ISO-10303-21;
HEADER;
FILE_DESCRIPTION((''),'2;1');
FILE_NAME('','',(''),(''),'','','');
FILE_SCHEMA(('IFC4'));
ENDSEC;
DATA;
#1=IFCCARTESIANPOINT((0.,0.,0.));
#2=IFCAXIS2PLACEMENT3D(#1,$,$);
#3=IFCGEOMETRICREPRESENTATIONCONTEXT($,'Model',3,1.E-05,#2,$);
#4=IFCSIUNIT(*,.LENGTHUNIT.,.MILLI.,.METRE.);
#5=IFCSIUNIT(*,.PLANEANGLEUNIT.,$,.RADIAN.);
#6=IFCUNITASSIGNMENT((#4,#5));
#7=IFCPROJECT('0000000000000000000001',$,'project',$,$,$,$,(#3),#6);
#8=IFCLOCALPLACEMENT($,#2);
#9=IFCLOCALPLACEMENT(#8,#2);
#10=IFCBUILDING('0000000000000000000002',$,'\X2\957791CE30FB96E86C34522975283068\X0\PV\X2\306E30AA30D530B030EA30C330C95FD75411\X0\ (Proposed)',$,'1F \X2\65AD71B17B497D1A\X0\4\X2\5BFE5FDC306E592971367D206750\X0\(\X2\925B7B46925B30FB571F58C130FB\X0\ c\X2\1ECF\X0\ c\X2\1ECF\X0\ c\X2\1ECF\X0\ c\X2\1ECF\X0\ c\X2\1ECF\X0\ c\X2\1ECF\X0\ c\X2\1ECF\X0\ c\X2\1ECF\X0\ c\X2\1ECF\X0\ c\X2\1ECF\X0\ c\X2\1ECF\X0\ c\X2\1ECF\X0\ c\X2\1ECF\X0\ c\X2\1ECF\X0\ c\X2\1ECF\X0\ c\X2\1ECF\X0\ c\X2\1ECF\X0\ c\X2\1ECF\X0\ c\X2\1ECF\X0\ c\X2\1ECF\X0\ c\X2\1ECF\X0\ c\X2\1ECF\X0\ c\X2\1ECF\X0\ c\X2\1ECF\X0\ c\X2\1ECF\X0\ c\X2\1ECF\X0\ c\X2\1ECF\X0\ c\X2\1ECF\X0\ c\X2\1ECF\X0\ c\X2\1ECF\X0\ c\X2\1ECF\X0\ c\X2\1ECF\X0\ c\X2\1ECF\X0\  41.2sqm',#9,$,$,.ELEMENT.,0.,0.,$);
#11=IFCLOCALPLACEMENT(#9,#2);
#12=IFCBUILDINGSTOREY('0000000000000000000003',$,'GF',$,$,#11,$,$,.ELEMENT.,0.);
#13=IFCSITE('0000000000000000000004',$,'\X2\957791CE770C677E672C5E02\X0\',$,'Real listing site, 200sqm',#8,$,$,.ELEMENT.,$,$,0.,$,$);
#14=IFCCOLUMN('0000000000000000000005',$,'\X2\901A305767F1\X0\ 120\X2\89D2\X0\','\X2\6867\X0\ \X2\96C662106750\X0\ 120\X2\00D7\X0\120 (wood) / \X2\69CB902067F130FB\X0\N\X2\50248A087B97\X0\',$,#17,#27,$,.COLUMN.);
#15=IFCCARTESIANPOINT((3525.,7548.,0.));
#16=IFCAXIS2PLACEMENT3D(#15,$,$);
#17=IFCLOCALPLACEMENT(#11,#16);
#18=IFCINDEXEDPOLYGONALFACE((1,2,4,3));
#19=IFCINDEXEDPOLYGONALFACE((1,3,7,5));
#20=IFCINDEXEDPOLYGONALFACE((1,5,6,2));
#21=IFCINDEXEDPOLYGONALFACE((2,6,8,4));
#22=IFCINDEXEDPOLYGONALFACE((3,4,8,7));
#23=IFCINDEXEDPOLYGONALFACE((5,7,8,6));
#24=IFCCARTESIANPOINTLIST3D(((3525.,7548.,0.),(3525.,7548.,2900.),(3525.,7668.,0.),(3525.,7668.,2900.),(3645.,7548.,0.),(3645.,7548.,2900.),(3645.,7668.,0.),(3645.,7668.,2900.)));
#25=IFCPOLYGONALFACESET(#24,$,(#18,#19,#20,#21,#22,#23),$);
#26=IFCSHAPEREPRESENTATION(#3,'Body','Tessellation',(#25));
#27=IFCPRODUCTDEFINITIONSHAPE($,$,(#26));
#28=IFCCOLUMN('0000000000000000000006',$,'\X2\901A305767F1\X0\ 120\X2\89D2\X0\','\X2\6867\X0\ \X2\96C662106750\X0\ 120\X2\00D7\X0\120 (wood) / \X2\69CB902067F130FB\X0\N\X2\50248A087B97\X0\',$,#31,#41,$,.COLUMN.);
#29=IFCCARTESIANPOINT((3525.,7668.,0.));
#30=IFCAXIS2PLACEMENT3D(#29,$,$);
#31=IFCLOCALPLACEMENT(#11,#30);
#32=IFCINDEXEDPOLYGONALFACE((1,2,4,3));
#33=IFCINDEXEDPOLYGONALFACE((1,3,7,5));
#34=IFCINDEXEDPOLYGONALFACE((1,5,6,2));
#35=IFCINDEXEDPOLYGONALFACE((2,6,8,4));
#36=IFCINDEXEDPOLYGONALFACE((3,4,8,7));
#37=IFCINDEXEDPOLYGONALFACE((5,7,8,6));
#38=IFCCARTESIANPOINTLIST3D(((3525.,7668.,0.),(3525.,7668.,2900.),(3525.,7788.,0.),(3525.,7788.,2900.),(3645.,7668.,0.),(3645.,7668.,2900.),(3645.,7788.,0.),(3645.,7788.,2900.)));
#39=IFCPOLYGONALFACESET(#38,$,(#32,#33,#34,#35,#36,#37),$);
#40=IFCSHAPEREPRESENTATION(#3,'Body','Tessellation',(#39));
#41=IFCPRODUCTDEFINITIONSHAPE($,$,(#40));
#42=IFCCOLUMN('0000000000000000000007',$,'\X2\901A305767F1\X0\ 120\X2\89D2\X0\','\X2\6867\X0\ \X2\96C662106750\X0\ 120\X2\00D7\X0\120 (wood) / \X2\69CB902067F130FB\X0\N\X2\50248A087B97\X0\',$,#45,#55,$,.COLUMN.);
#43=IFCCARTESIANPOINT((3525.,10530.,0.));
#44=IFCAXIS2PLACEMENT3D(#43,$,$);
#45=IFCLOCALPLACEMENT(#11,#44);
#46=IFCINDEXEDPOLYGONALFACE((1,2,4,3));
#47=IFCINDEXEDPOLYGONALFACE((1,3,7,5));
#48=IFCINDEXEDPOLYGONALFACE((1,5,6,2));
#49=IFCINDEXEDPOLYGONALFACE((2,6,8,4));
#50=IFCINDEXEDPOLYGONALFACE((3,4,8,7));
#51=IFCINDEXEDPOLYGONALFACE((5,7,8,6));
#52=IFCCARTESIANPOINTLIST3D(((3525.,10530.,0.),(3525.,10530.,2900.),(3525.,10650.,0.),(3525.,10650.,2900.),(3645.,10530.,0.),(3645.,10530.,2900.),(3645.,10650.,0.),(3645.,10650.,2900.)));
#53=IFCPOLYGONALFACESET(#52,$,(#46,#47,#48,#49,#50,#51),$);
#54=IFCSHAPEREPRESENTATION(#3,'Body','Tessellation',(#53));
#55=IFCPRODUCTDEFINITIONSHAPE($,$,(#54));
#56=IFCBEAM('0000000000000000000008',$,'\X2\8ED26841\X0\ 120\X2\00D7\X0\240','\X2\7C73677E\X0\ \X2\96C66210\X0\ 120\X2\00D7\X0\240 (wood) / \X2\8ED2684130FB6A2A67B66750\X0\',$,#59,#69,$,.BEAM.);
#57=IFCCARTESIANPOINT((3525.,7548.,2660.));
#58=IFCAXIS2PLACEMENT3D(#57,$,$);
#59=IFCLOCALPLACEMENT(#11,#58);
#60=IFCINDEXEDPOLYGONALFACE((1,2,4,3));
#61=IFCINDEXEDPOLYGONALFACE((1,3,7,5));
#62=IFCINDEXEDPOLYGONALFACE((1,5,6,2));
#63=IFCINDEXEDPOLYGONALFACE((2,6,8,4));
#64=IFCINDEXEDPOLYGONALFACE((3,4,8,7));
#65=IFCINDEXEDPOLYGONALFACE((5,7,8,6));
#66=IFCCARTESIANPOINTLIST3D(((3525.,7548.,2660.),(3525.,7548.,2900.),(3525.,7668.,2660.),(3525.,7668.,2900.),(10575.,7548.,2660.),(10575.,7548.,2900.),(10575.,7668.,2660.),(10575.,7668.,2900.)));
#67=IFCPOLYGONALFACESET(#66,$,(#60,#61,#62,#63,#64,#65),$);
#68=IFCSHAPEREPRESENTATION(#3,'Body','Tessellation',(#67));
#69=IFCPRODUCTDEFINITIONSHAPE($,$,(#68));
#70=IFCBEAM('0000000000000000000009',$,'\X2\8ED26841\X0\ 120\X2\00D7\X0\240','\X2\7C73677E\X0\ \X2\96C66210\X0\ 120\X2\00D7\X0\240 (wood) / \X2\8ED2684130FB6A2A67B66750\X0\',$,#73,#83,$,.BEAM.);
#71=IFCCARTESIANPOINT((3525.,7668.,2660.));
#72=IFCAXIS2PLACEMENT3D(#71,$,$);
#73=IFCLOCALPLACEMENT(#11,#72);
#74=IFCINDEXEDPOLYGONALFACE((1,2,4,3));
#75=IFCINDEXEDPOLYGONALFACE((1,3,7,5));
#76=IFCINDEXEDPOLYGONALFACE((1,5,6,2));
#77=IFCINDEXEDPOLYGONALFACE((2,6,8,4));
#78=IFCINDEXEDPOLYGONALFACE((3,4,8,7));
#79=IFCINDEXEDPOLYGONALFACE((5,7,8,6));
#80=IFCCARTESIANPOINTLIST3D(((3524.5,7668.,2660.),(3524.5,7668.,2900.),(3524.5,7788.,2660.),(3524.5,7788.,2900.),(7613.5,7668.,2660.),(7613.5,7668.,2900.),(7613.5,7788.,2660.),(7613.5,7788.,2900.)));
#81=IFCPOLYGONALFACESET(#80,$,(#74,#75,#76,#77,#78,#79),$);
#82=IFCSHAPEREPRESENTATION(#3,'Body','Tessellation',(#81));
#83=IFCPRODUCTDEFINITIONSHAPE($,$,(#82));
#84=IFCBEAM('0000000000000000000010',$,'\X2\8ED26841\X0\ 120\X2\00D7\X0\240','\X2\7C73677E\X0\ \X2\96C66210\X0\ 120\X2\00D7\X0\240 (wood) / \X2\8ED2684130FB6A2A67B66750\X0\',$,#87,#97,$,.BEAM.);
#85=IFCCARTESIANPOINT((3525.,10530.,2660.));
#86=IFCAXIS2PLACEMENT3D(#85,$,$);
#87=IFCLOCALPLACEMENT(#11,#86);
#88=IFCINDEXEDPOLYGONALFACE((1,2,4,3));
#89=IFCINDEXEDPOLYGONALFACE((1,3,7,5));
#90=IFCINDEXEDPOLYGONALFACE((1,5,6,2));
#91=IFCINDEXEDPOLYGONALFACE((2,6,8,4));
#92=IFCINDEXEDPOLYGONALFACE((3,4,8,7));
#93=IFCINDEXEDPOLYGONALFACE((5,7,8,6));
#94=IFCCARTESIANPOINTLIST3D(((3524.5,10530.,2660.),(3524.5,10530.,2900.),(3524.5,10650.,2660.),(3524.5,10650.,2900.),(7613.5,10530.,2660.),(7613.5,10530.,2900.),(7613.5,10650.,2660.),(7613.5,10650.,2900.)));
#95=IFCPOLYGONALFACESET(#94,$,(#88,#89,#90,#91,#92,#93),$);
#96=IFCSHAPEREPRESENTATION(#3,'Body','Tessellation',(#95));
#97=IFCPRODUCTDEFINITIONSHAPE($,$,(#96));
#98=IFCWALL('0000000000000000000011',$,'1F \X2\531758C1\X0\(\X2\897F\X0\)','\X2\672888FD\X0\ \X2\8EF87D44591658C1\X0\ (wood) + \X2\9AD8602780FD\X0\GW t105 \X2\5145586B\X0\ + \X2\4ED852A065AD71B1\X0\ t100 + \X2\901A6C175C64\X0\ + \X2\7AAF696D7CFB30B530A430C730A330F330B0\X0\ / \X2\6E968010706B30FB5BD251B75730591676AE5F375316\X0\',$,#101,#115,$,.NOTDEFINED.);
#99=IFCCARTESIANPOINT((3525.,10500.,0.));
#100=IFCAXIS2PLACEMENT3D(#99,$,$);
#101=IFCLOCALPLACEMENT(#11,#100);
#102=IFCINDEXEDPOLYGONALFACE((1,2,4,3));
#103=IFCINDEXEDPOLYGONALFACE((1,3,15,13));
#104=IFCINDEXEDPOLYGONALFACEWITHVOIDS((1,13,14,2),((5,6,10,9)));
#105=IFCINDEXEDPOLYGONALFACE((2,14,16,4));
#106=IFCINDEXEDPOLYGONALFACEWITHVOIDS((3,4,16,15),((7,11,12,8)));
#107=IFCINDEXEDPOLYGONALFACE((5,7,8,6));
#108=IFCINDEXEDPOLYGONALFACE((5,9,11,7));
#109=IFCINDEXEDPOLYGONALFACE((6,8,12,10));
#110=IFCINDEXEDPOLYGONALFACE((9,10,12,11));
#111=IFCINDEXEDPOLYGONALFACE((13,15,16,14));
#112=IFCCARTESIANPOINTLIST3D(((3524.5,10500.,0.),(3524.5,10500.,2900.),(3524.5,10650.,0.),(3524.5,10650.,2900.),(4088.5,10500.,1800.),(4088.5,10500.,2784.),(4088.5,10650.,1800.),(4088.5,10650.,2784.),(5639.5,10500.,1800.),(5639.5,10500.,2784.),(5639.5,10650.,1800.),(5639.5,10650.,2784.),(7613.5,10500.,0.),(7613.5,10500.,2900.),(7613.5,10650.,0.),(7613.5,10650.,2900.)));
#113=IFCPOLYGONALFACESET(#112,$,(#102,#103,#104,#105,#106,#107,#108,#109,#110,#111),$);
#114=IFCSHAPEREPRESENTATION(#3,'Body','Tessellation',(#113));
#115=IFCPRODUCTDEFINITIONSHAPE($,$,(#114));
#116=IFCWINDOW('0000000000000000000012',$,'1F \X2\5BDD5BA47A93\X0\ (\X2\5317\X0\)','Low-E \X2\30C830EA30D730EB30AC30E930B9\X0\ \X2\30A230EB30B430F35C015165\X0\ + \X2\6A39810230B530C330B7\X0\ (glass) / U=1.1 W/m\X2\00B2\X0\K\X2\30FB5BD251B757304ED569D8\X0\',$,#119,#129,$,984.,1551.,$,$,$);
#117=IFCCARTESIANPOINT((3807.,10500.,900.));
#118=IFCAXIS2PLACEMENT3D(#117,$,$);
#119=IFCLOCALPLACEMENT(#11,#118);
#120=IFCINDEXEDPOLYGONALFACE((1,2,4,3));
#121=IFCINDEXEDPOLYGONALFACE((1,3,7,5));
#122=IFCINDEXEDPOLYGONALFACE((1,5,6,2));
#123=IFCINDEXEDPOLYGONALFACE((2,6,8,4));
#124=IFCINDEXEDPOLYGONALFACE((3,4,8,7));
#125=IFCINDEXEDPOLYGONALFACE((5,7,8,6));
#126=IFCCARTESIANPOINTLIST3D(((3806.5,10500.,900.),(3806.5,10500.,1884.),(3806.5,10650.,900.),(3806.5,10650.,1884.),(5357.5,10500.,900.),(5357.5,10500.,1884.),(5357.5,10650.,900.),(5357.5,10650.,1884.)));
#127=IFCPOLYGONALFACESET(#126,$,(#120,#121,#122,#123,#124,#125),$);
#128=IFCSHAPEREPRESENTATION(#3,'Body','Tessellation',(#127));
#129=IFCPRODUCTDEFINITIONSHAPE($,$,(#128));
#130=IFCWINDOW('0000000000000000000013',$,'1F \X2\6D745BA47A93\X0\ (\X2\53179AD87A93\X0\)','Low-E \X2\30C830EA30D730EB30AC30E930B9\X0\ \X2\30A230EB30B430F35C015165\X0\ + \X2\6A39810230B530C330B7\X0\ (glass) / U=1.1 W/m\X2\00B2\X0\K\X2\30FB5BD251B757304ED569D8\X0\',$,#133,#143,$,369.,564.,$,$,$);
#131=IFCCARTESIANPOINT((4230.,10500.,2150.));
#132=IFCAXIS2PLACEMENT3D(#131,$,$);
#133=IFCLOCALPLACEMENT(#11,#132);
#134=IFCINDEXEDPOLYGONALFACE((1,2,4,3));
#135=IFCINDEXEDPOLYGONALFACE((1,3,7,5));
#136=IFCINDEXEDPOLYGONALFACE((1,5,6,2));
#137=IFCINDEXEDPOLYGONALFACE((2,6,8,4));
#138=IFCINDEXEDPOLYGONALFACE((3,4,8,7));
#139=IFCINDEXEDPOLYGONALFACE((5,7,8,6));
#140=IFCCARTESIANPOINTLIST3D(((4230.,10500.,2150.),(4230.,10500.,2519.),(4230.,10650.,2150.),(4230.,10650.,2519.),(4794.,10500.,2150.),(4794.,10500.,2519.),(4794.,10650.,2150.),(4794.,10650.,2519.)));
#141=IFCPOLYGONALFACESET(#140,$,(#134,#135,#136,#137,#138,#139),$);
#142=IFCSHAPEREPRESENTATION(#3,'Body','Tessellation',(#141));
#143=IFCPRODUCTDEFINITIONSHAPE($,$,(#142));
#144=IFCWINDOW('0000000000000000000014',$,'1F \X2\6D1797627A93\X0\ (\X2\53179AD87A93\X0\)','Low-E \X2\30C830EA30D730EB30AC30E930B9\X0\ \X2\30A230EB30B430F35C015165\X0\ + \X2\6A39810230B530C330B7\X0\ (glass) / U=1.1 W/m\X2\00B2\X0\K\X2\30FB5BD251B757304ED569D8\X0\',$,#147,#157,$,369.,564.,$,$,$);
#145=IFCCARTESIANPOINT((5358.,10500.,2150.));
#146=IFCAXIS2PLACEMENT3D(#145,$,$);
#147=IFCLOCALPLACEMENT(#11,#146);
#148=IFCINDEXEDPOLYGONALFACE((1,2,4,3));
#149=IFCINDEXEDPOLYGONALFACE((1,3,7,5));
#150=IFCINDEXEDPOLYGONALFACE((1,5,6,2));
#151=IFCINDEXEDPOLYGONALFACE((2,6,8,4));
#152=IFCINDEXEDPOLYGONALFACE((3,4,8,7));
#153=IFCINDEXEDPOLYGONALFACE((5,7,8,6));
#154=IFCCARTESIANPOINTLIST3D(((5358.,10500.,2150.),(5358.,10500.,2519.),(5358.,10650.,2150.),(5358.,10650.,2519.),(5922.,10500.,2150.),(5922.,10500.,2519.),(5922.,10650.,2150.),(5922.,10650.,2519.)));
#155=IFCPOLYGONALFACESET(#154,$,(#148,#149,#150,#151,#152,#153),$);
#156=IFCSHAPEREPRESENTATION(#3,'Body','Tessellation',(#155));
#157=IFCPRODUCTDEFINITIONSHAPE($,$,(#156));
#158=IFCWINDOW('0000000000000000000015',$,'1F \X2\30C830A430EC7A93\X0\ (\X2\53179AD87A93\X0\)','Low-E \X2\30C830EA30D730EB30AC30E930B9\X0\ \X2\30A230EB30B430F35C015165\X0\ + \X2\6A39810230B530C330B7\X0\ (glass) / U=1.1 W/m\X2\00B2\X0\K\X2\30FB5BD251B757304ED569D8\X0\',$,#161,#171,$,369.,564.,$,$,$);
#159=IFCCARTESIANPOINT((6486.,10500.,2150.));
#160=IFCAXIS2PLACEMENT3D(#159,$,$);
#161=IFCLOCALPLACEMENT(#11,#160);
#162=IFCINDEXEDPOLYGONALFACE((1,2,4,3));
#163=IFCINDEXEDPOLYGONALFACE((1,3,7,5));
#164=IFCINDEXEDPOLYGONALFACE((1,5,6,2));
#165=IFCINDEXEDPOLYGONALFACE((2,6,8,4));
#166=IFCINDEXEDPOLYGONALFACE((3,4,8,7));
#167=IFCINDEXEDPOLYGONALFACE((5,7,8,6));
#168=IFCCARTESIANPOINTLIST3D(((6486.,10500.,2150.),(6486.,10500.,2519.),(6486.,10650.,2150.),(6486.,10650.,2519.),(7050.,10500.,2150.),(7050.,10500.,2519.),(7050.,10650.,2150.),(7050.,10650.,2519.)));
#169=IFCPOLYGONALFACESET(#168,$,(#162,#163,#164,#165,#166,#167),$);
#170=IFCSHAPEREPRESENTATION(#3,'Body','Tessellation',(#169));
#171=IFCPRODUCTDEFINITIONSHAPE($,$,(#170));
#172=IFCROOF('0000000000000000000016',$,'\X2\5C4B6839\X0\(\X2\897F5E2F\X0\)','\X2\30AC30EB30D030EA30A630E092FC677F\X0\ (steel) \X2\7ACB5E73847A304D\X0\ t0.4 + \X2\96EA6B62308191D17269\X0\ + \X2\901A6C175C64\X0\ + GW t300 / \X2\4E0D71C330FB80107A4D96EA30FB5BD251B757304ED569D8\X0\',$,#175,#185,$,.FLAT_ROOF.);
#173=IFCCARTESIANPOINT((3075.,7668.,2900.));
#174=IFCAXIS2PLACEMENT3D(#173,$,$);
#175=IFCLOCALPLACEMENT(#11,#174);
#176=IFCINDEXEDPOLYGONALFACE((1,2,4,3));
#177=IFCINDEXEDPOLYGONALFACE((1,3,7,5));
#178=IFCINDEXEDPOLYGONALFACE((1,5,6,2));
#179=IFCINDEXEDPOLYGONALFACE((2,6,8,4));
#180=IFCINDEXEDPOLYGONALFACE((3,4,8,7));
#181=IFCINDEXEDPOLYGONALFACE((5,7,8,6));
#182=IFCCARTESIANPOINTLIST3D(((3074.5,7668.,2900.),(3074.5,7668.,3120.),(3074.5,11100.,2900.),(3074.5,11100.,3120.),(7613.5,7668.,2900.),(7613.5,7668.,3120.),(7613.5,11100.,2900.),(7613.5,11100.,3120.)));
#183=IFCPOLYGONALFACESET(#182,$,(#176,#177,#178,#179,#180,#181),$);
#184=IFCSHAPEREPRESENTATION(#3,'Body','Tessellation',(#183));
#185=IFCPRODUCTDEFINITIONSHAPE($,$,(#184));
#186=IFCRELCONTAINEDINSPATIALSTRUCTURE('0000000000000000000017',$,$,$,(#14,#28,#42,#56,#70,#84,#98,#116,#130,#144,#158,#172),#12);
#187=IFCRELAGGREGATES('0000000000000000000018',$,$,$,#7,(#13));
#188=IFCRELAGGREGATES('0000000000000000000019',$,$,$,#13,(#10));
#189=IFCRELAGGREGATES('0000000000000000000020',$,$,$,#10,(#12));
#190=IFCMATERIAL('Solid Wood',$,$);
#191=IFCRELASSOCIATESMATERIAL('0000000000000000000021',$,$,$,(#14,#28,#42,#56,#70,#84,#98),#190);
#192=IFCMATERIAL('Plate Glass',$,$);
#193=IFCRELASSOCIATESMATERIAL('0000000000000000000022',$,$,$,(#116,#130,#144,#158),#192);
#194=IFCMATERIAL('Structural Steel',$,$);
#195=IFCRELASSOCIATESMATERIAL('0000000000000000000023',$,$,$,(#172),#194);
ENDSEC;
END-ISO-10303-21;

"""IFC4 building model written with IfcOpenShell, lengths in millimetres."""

from ifc_helpers import new_model, si_unit, frame, frame_2d, origin, place, context, project, spatial, rectangle, extrude, material, element, fill, save


model = new_model("IFC4")

# Units and contexts
model_context = context("Model", 3, precision=1e-05, world=origin())
ifc_project = project(units=[si_unit("LENGTHUNIT", "METRE", prefix="MILLI"), si_unit("PLANEANGLEUNIT", "RADIAN")], contexts=[model_context])

# Site, building, storey
site_placement = place(None, origin())
site = spatial("IfcSite", under=ifc_project, at=site_placement, Name="長野県松本市", ObjectType="Real listing site, 200sqm", CompositionType="ELEMENT", RefElevation=0.0)
building_placement = place(site_placement, origin())
building = spatial("IfcBuilding", under=site, at=building_placement, Name="長野・雨水利用とPVのオフグリッド志向 (Proposed)", ObjectType="1F 断熱等級4対応の天然素材(鉛筆鉛・土壁・ cỏ cỏ cỏ cỏ cỏ cỏ cỏ cỏ cỏ cỏ cỏ cỏ cỏ cỏ cỏ cỏ cỏ cỏ cỏ cỏ cỏ cỏ cỏ cỏ cỏ cỏ cỏ cỏ cỏ cỏ cỏ cỏ cỏ  41.2sqm", CompositionType="ELEMENT", ElevationOfRefHeight=0.0, ElevationOfTerrain=0.0)
storey_placement = place(building_placement, origin())
storey = spatial("IfcBuildingStorey", under=building, at=storey_placement, Name="GF", CompositionType="ELEMENT", Elevation=0.0)

# Columns
ifc_material_1 = material(Name="Solid Wood")
column_1_placement = place(storey_placement, frame((3525.0, 7548.0, 0.0)))
element("IfcColumn", 1, at=column_1_placement, inside=storey, material=ifc_material_1, Name="通し柱 120角", Description="桧 集成材 120×120 (wood) / 構造柱・N値計算", PredefinedType="COLUMN", context=model_context, shape_type="SweptSolid", body=[
    extrude(rectangle(XDim=120.0, YDim=120.0, at=frame_2d((60.0, 60.0))), frame((3525.0, 7548.0, 0.0)), (0.0, 0.0, 1.0), 2900.0),
])
column_2_placement = place(storey_placement, frame((3525.0, 7668.0, 0.0)))
element("IfcColumn", 2, at=column_2_placement, inside=storey, material=ifc_material_1, Name="通し柱 120角", Description="桧 集成材 120×120 (wood) / 構造柱・N値計算", PredefinedType="COLUMN", context=model_context, shape_type="SweptSolid", body=[
    extrude(rectangle(XDim=120.0, YDim=120.0, at=frame_2d((60.0, 60.0))), frame((3525.0, 7668.0, 0.0)), (0.0, 0.0, 1.0), 2900.0),
])
column_3_placement = place(storey_placement, frame((3525.0, 10530.0, 0.0)))
element("IfcColumn", 3, at=column_3_placement, inside=storey, material=ifc_material_1, Name="通し柱 120角", Description="桧 集成材 120×120 (wood) / 構造柱・N値計算", PredefinedType="COLUMN", context=model_context, shape_type="SweptSolid", body=[
    extrude(rectangle(XDim=120.0, YDim=120.0, at=frame_2d((60.0, 60.0))), frame((3525.0, 10530.0, 0.0)), (0.0, 0.0, 1.0), 2900.0),
])

# Beams
beam_1_placement = place(storey_placement, frame((3525.0, 7548.0, 2660.0)))
element("IfcBeam", 4, at=beam_1_placement, inside=storey, material=ifc_material_1, Name="軒桁 120×240", Description="米松 集成 120×240 (wood) / 軒桁・横架材", PredefinedType="BEAM", context=model_context, shape_type="SweptSolid", body=[
    extrude(rectangle(XDim=7050.0, YDim=120.0, at=frame_2d((3525.0, 60.0))), frame((3525.0, 7548.0, 2660.0)), (0.0, 0.0, 1.0), 240.0),
])
beam_2_placement = place(storey_placement, frame((3525.0, 7668.0, 2660.0)))
element("IfcBeam", 5, at=beam_2_placement, inside=storey, material=ifc_material_1, Name="軒桁 120×240", Description="米松 集成 120×240 (wood) / 軒桁・横架材", PredefinedType="BEAM", context=model_context, shape_type="SweptSolid", body=[
    extrude(rectangle(XDim=4089.0, YDim=120.0, at=frame_2d((2044.0, 60.0))), frame((3525.0, 7668.0, 2660.0)), (0.0, 0.0, 1.0), 240.0),
])
beam_3_placement = place(storey_placement, frame((3525.0, 10530.0, 2660.0)))
element("IfcBeam", 6, at=beam_3_placement, inside=storey, material=ifc_material_1, Name="軒桁 120×240", Description="米松 集成 120×240 (wood) / 軒桁・横架材", PredefinedType="BEAM", context=model_context, shape_type="SweptSolid", body=[
    extrude(rectangle(XDim=4089.0, YDim=120.0, at=frame_2d((2044.0, 60.0))), frame((3525.0, 10530.0, 2660.0)), (0.0, 0.0, 1.0), 240.0),
])

# Wall, openings, windows
wall_1_placement = place(storey_placement, frame((3525.0, 10500.0, 0.0)))
wall_1 = element("IfcWall", 7, at=wall_1_placement, inside=storey, material=ifc_material_1, Name="1F 北壁(西)", Description="木製 軸組外壁 (wood) + 高性能GW t105 充填 + 付加断熱 t100 + 通気層 + 窯業系サイディング / 準耐火・寒冷地外皮強化", PredefinedType="NOTDEFINED", context=model_context, shape_type="SweptSolid", body=[
    extrude(rectangle(XDim=4089.0, YDim=150.0, at=frame_2d((2044.0, 75.0))), frame((3525.0, 10500.0, 0.0)), (0.0, 0.0, 1.0), 2900.0),
])
opening_1_placement = place(storey_placement, frame((3807.0, 10500.0, 900.0)))
opening_1 = element("IfcOpeningElement", 8, at=opening_1_placement, cuts=wall_1, PredefinedType="NOTDEFINED", context=model_context, shape_type="SweptSolid", body=[
    extrude(rectangle(XDim=1551.0, YDim=150.0, at=frame_2d((775.0, 75.0))), frame((3807.0, 10500.0, 900.0)), (0.0, 0.0, 1.0), 984.0),
])
opening_2_placement = place(storey_placement, frame((4230.0, 10500.0, 2150.0)))
opening_2 = element("IfcOpeningElement", 9, at=opening_2_placement, cuts=wall_1, PredefinedType="NOTDEFINED", context=model_context, shape_type="SweptSolid", body=[
    extrude(rectangle(XDim=564.0, YDim=150.0, at=frame_2d((282.0, 75.0))), frame((4230.0, 10500.0, 2150.0)), (0.0, 0.0, 1.0), 369.0),
])
opening_3_placement = place(storey_placement, frame((5358.0, 10500.0, 2150.0)))
opening_3 = element("IfcOpeningElement", 10, at=opening_3_placement, cuts=wall_1, PredefinedType="NOTDEFINED", context=model_context, shape_type="SweptSolid", body=[
    extrude(rectangle(XDim=564.0, YDim=150.0, at=frame_2d((282.0, 75.0))), frame((5358.0, 10500.0, 2150.0)), (0.0, 0.0, 1.0), 369.0),
])
opening_4_placement = place(storey_placement, frame((6486.0, 10500.0, 2150.0)))
opening_4 = element("IfcOpeningElement", 11, at=opening_4_placement, cuts=wall_1, PredefinedType="NOTDEFINED", context=model_context, shape_type="SweptSolid", body=[
    extrude(rectangle(XDim=564.0, YDim=150.0, at=frame_2d((282.0, 75.0))), frame((6486.0, 10500.0, 2150.0)), (0.0, 0.0, 1.0), 369.0),
])
ifc_material_2 = material(Name="Plate Glass")
window_1_placement = place(storey_placement, frame((3807.0, 10500.0, 900.0)))
window_1 = element("IfcWindow", 12, at=window_1_placement, inside=storey, material=ifc_material_2, Name="1F 寝室窓 (北)", Description="Low-E トリプルガラス アルゴン封入 + 樹脂サッシ (glass) / U=1.1 W/m²K・寒冷地仕様", OverallHeight=984.0, OverallWidth=1551.0, context=model_context, shape_type="SweptSolid", body=[
    extrude(rectangle(XDim=1551.0, YDim=150.0, at=frame_2d((775.0, 75.0))), frame((3807.0, 10500.0, 900.0)), (0.0, 0.0, 1.0), 984.0),
])
fill(opening_1, window_1)
window_2_placement = place(storey_placement, frame((4230.0, 10500.0, 2150.0)))
window_2 = element("IfcWindow", 13, at=window_2_placement, inside=storey, material=ifc_material_2, Name="1F 浴室窓 (北高窓)", Description="Low-E トリプルガラス アルゴン封入 + 樹脂サッシ (glass) / U=1.1 W/m²K・寒冷地仕様", OverallHeight=369.0, OverallWidth=564.0, context=model_context, shape_type="SweptSolid", body=[
    extrude(rectangle(XDim=564.0, YDim=150.0, at=frame_2d((282.0, 75.0))), frame((4230.0, 10500.0, 2150.0)), (0.0, 0.0, 1.0), 369.0),
])
fill(opening_2, window_2)
window_3_placement = place(storey_placement, frame((5358.0, 10500.0, 2150.0)))
window_3 = element("IfcWindow", 14, at=window_3_placement, inside=storey, material=ifc_material_2, Name="1F 洗面窓 (北高窓)", Description="Low-E トリプルガラス アルゴン封入 + 樹脂サッシ (glass) / U=1.1 W/m²K・寒冷地仕様", OverallHeight=369.0, OverallWidth=564.0, context=model_context, shape_type="SweptSolid", body=[
    extrude(rectangle(XDim=564.0, YDim=150.0, at=frame_2d((282.0, 75.0))), frame((5358.0, 10500.0, 2150.0)), (0.0, 0.0, 1.0), 369.0),
])
fill(opening_3, window_3)
window_4_placement = place(storey_placement, frame((6486.0, 10500.0, 2150.0)))
window_4 = element("IfcWindow", 15, at=window_4_placement, inside=storey, material=ifc_material_2, Name="1F トイレ窓 (北高窓)", Description="Low-E トリプルガラス アルゴン封入 + 樹脂サッシ (glass) / U=1.1 W/m²K・寒冷地仕様", OverallHeight=369.0, OverallWidth=564.0, context=model_context, shape_type="SweptSolid", body=[
    extrude(rectangle(XDim=564.0, YDim=150.0, at=frame_2d((282.0, 75.0))), frame((6486.0, 10500.0, 2150.0)), (0.0, 0.0, 1.0), 369.0),
])
fill(opening_4, window_4)

# Roof
ifc_material_3 = material(Name="Structural Steel")
roof_placement = place(storey_placement, frame((3075.0, 7668.0, 2900.0)))
element("IfcRoof", 16, at=roof_placement, inside=storey, material=ifc_material_3, Name="屋根(西帯)", Description="ガルバリウム鋼板 (steel) 立平葺き t0.4 + 雪止め金物 + 通気層 + GW t300 / 不燃・耐積雪・寒冷地仕様", PredefinedType="FLAT_ROOF", context=model_context, shape_type="SweptSolid", body=[
    extrude(rectangle(XDim=4539.0, YDim=3432.0, at=frame_2d((2269.0, 1716.0))), frame((3075.0, 7668.0, 2900.0)), (0.0, 0.0, 1.0), 220.0),
])

save(model, "model.ifc")
